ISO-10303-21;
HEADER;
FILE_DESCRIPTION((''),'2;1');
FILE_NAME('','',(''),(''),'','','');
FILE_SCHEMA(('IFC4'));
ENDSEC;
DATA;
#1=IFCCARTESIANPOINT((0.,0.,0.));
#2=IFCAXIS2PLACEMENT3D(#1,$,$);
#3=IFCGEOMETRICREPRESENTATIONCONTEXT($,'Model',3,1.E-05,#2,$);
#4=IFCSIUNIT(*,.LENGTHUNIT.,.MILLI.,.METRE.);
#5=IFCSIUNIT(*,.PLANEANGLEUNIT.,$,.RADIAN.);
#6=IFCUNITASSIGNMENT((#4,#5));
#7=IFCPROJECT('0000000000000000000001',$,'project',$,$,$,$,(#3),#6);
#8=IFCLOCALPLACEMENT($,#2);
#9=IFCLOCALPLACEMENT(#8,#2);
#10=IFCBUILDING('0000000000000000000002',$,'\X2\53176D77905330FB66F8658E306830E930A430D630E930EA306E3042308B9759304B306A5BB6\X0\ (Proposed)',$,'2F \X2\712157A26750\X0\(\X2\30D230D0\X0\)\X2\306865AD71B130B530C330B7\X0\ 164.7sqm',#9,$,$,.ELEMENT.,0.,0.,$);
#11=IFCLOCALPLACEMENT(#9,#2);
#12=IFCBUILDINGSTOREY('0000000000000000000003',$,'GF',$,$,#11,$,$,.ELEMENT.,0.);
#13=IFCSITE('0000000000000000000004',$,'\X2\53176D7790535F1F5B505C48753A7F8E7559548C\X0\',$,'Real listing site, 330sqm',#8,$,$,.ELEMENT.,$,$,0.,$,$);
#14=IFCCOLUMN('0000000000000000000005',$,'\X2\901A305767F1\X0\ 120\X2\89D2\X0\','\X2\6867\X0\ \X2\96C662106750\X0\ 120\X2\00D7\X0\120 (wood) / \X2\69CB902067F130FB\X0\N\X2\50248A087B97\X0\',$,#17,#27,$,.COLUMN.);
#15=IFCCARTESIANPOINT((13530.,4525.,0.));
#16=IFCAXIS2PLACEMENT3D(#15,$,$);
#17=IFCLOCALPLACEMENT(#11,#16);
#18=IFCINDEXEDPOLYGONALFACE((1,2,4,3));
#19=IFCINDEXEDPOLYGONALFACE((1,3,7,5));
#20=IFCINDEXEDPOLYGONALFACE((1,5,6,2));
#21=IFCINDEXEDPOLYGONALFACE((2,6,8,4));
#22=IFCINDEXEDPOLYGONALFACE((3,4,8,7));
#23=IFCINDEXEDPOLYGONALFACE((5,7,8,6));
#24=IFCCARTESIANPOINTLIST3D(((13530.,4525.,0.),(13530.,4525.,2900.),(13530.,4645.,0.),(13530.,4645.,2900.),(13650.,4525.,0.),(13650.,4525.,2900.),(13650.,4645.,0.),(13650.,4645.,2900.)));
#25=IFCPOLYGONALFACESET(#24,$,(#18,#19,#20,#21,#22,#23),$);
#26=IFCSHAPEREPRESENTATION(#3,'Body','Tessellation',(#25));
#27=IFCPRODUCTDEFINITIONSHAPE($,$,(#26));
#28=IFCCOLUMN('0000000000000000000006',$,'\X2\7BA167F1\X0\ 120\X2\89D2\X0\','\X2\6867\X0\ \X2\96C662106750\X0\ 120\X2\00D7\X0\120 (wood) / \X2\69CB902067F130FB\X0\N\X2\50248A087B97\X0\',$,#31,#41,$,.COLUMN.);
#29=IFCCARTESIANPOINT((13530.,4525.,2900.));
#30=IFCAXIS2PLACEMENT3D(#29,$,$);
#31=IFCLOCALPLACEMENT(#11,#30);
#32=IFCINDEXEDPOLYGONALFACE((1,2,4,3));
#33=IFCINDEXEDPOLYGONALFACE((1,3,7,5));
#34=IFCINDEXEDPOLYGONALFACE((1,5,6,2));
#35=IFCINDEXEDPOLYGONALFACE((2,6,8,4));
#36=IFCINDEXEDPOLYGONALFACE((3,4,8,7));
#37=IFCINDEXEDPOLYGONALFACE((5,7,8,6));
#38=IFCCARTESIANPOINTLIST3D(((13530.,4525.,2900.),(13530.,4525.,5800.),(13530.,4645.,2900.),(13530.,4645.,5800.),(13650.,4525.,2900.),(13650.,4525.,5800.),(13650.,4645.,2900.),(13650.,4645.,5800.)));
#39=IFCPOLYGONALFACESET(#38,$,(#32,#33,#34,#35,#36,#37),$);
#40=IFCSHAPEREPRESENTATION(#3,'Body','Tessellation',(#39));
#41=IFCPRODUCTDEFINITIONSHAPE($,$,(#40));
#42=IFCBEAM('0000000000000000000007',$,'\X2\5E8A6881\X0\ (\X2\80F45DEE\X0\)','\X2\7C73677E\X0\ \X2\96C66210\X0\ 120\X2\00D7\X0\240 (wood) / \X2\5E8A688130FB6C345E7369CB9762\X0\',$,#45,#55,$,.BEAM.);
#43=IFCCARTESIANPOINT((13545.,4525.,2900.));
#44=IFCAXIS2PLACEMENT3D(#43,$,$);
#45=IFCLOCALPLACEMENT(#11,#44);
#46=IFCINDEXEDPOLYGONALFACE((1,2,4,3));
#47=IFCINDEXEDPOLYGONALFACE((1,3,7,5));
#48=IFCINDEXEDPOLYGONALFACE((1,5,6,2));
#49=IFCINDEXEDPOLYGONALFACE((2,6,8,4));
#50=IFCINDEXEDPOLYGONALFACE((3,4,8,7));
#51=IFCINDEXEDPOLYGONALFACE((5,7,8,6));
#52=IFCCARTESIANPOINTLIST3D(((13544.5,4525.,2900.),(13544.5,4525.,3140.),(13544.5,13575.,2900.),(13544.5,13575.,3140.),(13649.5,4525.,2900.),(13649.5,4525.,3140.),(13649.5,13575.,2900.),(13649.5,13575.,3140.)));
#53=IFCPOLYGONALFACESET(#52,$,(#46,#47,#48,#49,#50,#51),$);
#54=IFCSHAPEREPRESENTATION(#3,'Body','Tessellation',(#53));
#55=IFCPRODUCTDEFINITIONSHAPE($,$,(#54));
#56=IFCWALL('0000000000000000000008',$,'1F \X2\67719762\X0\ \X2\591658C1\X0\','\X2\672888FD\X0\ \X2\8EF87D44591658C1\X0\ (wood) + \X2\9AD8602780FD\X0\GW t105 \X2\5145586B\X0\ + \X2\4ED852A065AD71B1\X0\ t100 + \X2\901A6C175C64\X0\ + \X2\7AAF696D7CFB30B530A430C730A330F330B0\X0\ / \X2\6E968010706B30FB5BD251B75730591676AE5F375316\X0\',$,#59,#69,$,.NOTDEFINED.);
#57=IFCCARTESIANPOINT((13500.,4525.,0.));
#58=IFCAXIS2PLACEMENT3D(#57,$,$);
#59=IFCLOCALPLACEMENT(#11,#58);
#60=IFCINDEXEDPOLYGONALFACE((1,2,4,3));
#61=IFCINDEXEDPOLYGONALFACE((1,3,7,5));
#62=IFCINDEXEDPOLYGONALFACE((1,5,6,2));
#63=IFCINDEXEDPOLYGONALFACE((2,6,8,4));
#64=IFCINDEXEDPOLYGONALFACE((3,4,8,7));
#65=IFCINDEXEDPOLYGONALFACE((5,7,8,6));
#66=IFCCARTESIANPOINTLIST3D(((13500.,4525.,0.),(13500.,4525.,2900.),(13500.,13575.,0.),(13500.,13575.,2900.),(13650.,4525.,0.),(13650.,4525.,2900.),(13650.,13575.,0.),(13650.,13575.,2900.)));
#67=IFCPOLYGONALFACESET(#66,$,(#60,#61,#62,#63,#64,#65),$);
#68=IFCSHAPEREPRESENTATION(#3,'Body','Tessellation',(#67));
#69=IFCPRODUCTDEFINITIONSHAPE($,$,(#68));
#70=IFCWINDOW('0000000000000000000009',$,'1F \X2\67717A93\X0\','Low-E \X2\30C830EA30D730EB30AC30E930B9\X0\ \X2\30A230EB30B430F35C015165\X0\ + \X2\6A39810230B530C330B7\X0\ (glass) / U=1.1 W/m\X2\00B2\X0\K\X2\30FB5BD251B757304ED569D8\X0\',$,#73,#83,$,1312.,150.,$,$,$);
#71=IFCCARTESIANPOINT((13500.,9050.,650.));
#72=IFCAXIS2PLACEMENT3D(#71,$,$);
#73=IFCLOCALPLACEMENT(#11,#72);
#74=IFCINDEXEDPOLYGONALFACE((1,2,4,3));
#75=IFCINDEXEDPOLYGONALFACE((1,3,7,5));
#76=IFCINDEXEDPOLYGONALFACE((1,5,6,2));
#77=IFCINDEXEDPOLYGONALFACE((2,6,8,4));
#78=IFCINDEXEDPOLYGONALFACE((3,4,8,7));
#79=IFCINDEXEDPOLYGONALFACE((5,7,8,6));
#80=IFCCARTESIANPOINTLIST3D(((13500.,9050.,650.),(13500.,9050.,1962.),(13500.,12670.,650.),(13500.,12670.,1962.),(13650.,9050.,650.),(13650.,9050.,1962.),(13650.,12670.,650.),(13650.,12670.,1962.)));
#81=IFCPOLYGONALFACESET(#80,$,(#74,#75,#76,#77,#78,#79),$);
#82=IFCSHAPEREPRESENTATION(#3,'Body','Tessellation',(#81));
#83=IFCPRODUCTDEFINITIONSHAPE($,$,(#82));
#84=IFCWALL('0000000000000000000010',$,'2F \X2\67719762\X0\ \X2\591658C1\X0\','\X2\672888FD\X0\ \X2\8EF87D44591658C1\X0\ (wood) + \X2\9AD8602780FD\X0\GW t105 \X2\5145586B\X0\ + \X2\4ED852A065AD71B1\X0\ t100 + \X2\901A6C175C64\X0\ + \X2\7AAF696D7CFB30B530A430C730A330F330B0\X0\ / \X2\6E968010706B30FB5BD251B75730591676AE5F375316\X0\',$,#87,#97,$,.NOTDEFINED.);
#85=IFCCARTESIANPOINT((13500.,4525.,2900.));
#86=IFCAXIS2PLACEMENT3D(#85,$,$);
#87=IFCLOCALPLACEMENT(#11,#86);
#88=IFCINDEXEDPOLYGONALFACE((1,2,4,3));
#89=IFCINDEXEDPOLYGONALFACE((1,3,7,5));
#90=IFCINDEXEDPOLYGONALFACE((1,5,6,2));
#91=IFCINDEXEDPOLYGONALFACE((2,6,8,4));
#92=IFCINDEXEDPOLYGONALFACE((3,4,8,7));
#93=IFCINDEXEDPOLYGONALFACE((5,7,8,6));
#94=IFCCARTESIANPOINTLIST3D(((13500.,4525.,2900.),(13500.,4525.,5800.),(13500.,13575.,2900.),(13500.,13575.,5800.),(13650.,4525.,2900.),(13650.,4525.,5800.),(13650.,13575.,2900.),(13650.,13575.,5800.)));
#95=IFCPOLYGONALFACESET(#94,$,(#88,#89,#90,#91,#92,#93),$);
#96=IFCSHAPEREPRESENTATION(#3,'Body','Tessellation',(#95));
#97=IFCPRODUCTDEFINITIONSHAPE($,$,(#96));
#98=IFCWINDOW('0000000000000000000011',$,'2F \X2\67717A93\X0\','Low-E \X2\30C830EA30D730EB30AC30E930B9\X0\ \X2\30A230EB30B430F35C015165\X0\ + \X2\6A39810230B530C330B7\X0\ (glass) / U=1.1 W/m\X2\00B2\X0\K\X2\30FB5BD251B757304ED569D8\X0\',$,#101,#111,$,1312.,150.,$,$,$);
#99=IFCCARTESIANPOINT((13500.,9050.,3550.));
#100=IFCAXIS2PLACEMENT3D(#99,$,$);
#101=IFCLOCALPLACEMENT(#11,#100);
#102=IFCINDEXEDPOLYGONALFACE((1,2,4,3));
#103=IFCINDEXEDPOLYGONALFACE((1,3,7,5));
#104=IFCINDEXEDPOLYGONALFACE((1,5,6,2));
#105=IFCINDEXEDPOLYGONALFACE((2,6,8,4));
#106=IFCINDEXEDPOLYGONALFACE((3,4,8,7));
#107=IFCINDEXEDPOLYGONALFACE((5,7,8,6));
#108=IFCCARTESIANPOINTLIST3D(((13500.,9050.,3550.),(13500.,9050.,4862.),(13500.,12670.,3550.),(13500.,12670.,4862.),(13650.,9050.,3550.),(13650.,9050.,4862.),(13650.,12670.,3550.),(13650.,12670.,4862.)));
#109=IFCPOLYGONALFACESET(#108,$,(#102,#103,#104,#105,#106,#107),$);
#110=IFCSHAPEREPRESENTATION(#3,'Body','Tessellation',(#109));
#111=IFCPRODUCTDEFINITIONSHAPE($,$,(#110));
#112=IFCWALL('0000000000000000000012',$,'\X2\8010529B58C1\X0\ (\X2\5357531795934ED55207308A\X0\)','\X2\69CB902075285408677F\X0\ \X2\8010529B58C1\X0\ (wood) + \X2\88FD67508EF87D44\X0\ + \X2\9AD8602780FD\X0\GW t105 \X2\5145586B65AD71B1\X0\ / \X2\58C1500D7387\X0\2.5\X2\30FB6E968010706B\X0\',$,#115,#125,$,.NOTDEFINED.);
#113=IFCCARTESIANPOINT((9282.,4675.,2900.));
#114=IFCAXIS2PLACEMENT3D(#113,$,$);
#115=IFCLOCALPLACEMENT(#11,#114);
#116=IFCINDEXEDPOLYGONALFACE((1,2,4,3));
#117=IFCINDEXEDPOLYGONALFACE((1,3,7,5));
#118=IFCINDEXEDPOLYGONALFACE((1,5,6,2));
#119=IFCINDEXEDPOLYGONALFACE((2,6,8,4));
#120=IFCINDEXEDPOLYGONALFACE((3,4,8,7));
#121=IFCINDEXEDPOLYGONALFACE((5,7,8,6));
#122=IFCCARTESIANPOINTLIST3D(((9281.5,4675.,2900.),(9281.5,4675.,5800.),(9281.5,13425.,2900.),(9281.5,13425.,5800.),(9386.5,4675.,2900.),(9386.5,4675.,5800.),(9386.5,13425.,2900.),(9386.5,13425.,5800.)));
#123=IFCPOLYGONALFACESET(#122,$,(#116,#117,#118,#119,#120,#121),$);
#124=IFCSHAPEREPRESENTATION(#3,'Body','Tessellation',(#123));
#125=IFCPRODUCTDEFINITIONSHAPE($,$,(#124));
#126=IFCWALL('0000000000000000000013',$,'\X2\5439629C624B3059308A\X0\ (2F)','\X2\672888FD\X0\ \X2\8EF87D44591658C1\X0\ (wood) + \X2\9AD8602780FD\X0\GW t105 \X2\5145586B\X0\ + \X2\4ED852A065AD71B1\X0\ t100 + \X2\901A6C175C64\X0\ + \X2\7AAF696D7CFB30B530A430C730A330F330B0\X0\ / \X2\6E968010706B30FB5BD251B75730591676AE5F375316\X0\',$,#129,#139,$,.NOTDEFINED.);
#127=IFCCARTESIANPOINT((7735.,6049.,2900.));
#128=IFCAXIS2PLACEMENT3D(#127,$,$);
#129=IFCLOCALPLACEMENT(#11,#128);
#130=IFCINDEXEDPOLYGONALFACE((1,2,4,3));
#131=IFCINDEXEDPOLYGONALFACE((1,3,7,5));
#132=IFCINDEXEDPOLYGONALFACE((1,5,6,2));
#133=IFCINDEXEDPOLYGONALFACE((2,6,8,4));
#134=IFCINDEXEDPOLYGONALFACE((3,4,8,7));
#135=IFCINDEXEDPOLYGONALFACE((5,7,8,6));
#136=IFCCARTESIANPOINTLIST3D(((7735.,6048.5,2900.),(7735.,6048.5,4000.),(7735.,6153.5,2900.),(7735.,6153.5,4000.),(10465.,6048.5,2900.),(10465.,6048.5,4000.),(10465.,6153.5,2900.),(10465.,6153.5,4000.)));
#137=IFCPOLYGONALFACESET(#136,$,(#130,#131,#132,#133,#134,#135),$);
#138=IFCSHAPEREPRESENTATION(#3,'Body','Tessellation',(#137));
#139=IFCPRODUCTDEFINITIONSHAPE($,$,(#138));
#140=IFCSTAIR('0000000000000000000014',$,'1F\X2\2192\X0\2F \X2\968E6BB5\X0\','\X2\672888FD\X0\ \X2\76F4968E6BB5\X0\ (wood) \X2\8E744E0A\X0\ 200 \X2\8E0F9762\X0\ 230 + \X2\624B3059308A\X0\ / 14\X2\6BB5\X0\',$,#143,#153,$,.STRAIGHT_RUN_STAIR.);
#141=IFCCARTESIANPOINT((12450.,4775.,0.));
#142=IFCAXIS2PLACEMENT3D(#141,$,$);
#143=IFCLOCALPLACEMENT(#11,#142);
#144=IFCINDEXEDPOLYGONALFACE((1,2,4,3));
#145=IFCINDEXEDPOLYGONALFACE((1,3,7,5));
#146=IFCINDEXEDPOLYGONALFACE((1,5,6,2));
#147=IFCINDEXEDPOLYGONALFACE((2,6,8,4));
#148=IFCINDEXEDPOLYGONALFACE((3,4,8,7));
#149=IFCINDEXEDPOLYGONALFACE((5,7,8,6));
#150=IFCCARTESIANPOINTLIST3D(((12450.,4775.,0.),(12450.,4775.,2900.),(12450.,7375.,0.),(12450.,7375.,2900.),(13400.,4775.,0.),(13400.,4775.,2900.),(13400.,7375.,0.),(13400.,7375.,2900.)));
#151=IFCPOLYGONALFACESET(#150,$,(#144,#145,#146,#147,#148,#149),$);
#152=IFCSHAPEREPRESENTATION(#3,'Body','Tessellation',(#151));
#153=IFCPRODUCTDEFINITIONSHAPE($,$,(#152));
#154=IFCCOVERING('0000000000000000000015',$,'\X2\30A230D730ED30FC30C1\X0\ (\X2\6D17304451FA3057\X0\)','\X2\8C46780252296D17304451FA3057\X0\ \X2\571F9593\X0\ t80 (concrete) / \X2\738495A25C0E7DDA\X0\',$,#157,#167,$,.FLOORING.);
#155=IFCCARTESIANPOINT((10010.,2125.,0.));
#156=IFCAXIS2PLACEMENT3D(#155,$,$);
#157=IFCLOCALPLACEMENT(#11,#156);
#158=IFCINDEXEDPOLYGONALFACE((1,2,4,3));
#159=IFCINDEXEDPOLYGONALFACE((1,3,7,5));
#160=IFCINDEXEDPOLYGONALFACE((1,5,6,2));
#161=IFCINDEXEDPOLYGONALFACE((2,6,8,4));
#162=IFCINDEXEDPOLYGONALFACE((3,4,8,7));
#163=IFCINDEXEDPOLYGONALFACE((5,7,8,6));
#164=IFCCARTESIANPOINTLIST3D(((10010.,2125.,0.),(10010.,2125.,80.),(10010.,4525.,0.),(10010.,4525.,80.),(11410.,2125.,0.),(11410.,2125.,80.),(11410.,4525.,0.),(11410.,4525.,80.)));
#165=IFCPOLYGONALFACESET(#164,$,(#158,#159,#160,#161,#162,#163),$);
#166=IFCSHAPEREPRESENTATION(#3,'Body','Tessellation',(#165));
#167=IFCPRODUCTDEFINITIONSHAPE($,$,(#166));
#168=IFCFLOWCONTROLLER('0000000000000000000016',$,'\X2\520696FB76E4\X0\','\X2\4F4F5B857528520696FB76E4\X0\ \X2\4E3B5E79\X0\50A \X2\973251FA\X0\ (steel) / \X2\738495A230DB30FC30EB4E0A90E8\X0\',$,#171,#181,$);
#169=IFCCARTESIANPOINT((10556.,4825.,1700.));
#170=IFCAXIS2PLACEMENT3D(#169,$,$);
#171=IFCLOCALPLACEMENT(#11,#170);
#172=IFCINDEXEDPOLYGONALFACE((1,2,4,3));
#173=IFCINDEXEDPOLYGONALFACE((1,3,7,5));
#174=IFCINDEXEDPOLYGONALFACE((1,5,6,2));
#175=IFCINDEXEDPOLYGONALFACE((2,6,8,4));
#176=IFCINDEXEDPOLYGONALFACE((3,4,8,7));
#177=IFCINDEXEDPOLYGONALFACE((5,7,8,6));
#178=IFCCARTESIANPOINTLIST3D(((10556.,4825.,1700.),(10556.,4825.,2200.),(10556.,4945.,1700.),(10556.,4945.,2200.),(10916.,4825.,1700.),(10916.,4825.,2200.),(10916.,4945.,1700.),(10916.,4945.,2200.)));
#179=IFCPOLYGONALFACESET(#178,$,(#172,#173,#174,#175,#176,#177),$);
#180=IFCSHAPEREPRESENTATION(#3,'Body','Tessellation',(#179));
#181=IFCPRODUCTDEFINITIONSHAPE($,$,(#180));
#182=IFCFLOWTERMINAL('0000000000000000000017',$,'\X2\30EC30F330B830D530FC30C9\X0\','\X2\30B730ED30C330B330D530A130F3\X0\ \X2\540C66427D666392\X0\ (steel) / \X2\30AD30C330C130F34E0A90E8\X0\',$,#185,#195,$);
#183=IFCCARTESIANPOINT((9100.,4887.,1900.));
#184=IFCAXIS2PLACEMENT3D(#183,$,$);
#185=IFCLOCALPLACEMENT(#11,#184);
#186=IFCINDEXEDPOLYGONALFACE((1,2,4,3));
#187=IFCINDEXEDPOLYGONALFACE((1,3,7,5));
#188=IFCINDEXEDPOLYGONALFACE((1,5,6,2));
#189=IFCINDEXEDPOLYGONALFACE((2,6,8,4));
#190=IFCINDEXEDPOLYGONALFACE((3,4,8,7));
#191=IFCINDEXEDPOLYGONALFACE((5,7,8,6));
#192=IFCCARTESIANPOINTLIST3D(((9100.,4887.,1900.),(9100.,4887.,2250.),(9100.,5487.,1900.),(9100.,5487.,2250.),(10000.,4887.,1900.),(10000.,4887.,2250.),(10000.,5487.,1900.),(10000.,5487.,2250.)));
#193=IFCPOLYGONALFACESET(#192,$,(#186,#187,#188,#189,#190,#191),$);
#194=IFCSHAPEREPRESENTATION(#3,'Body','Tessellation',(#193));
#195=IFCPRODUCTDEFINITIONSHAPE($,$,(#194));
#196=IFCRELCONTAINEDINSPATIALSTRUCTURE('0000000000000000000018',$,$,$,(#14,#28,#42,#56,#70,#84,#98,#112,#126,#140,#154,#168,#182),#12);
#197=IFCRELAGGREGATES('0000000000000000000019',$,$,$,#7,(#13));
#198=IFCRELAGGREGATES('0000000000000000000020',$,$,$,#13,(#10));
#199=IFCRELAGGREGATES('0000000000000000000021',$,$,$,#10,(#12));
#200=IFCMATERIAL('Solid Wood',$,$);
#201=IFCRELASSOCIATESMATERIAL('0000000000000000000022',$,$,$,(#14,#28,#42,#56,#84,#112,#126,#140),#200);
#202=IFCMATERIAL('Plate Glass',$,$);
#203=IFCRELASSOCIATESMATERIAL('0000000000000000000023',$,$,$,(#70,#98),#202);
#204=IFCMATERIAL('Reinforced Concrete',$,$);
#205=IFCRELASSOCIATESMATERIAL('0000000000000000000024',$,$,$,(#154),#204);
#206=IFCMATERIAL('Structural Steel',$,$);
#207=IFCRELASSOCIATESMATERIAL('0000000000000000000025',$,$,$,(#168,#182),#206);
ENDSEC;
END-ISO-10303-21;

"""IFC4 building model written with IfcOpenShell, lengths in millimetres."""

from ifc_helpers import new_model, si_unit, frame, frame_2d, origin, place, context, project, spatial, rectangle, extrude, material, element, fill, save


model = new_model("IFC4")

# Units and contexts
model_context = context("Model", 3, precision=1e-05, world=origin())
ifc_project = project(units=[si_unit("LENGTHUNIT", "METRE", prefix="MILLI"), si_unit("PLANEANGLEUNIT", "RADIAN")], contexts=[model_context])

# Site, building, storey
site_placement = place(None, origin())
site = spatial("IfcSite", under=ifc_project, at=site_placement, Name="北海道弟子屈町美留和", ObjectType="Real listing site, 330sqm", CompositionType="ELEMENT", RefElevation=0.0)
building_placement = place(site_placement, origin())
building = spatial("IfcBuilding", under=site, at=building_placement, Name="北海道・書斎とライブラリのある静かな家 (Proposed)", ObjectType="2F 無垢材(ヒバ)と断熱サッシ 164.7sqm", CompositionType="ELEMENT", ElevationOfRefHeight=0.0, ElevationOfTerrain=0.0)
storey_placement = place(building_placement, origin())
storey = spatial("IfcBuildingStorey", under=building, at=storey_placement, Name="GF", CompositionType="ELEMENT", Elevation=0.0)

# Columns
ifc_material_1 = material(Name="Solid Wood")
column_1_placement = place(storey_placement, frame((13530.0, 4525.0, 0.0)))
element("IfcColumn", 1, at=column_1_placement, inside=storey, material=ifc_material_1, Name="通し柱 120角", Description="桧 集成材 120×120 (wood) / 構造柱・N値計算", PredefinedType="COLUMN", context=model_context, shape_type="SweptSolid", body=[
    extrude(rectangle(XDim=120.0, YDim=120.0, at=frame_2d((60.0, 60.0))), frame((13530.0, 4525.0, 0.0)), (0.0, 0.0, 1.0), 2900.0),
])
column_2_placement = place(storey_placement, frame((13530.0, 4525.0, 2900.0)))
element("IfcColumn", 2, at=column_2_placement, inside=storey, material=ifc_material_1, Name="管柱 120角", Description="桧 集成材 120×120 (wood) / 構造柱・N値計算", PredefinedType="COLUMN", context=model_context, shape_type="SweptSolid", body=[
    extrude(rectangle(XDim=120.0, YDim=120.0, at=frame_2d((60.0, 60.0))), frame((13530.0, 4525.0, 2900.0)), (0.0, 0.0, 1.0), 2900.0),
])

# Beam
beam_1_placement = place(storey_placement, frame((13545.0, 4525.0, 2900.0)))
element("IfcBeam", 3, at=beam_1_placement, inside=storey, material=ifc_material_1, Name="床梁 (胴差)", Description="米松 集成 120×240 (wood) / 床梁・水平構面", PredefinedType="BEAM", context=model_context, shape_type="SweptSolid", body=[
    extrude(rectangle(XDim=105.0, YDim=9050.0, at=frame_2d((52.0, 4525.0))), frame((13545.0, 4525.0, 2900.0)), (0.0, 0.0, 1.0), 240.0),
])

# Wall, opening, window
wall_1_placement = place(storey_placement, frame((13500.0, 4525.0, 0.0)))
wall_1 = element("IfcWall", 4, at=wall_1_placement, inside=storey, material=ifc_material_1, Name="1F 東面 外壁", Description="木製 軸組外壁 (wood) + 高性能GW t105 充填 + 付加断熱 t100 + 通気層 + 窯業系サイディング / 準耐火・寒冷地外皮強化", PredefinedType="NOTDEFINED", context=model_context, shape_type="SweptSolid", body=[
    extrude(rectangle(XDim=150.0, YDim=9050.0, at=frame_2d((75.0, 4525.0))), frame((13500.0, 4525.0, 0.0)), (0.0, 0.0, 1.0), 2900.0),
])
opening_1_placement = place(storey_placement, frame((13500.0, 9050.0, 650.0)))
opening_1 = element("IfcOpeningElement", 5, at=opening_1_placement, cuts=wall_1, PredefinedType="NOTDEFINED", context=model_context, shape_type="SweptSolid", body=[
    extrude(rectangle(XDim=150.0, YDim=3620.0, at=frame_2d((75.0, 1810.0))), frame((13500.0, 9050.0, 650.0)), (0.0, 0.0, 1.0), 1312.0),
])
ifc_material_2 = material(Name="Plate Glass")
window_1_placement = place(storey_placement, frame((13500.0, 9050.0, 650.0)))
window_1 = element("IfcWindow", 6, at=window_1_placement, inside=storey, material=ifc_material_2, Name="1F 東窓", Description="Low-E トリプルガラス アルゴン封入 + 樹脂サッシ (glass) / U=1.1 W/m²K・寒冷地仕様", OverallHeight=1312.0, OverallWidth=150.0, context=model_context, shape_type="SweptSolid", body=[
    extrude(rectangle(XDim=150.0, YDim=3620.0, at=frame_2d((75.0, 1810.0))), frame((13500.0, 9050.0, 650.0)), (0.0, 0.0, 1.0), 1312.0),
])
fill(opening_1, window_1)

# Wall, opening, window
wall_2_placement = place(storey_placement, frame((13500.0, 4525.0, 2900.0)))
wall_2 = element("IfcWall", 7, at=wall_2_placement, inside=storey, material=ifc_material_1, Name="2F 東面 外壁", Description="木製 軸組外壁 (wood) + 高性能GW t105 充填 + 付加断熱 t100 + 通気層 + 窯業系サイディング / 準耐火・寒冷地外皮強化", PredefinedType="NOTDEFINED", context=model_context, shape_type="SweptSolid", body=[
    extrude(rectangle(XDim=150.0, YDim=9050.0, at=frame_2d((75.0, 4525.0))), frame((13500.0, 4525.0, 2900.0)), (0.0, 0.0, 1.0), 2900.0),
])
opening_2_placement = place(storey_placement, frame((13500.0, 9050.0, 3550.0)))
opening_2 = element("IfcOpeningElement", 8, at=opening_2_placement, cuts=wall_2, PredefinedType="NOTDEFINED", context=model_context, shape_type="SweptSolid", body=[
    extrude(rectangle(XDim=150.0, YDim=3620.0, at=frame_2d((75.0, 1810.0))), frame((13500.0, 9050.0, 3550.0)), (0.0, 0.0, 1.0), 1312.0),
])
window_2_placement = place(storey_placement, frame((13500.0, 9050.0, 3550.0)))
window_2 = element("IfcWindow", 9, at=window_2_placement, inside=storey, material=ifc_material_2, Name="2F 東窓", Description="Low-E トリプルガラス アルゴン封入 + 樹脂サッシ (glass) / U=1.1 W/m²K・寒冷地仕様", OverallHeight=1312.0, OverallWidth=150.0, context=model_context, shape_type="SweptSolid", body=[
    extrude(rectangle(XDim=150.0, YDim=3620.0, at=frame_2d((75.0, 1810.0))), frame((13500.0, 9050.0, 3550.0)), (0.0, 0.0, 1.0), 1312.0),
])
fill(opening_2, window_2)

# Walls
wall_3_placement = place(storey_placement, frame((9282.0, 4675.0, 2900.0)))
element("IfcWall", 10, at=wall_3_placement, inside=storey, material=ifc_material_1, Name="耐力壁 (南北間仕切り)", Description="構造用合板 耐力壁 (wood) + 製材軸組 + 高性能GW t105 充填断熱 / 壁倍率2.5・準耐火", PredefinedType="NOTDEFINED", context=model_context, shape_type="SweptSolid", body=[
    extrude(rectangle(XDim=105.0, YDim=8750.0, at=frame_2d((52.0, 4375.0))), frame((9282.0, 4675.0, 2900.0)), (0.0, 0.0, 1.0), 2900.0),
])
wall_4_placement = place(storey_placement, frame((7735.0, 6049.0, 2900.0)))
element("IfcWall", 11, at=wall_4_placement, inside=storey, material=ifc_material_1, Name="吹抜手すり (2F)", Description="木製 軸組外壁 (wood) + 高性能GW t105 充填 + 付加断熱 t100 + 通気層 + 窯業系サイディング / 準耐火・寒冷地外皮強化", PredefinedType="NOTDEFINED", context=model_context, shape_type="SweptSolid", body=[
    extrude(rectangle(XDim=2730.0, YDim=105.0, at=frame_2d((1365.0, 52.0))), frame((7735.0, 6049.0, 2900.0)), (0.0, 0.0, 1.0), 1100.0),
])

# Stair
stair_placement = place(storey_placement, frame((12450.0, 4775.0, 0.0)))
element("IfcStair", 12, at=stair_placement, inside=storey, material=ifc_material_1, Name="1F→2F 階段", Description="木製 直階段 (wood) 蹴上 200 踏面 230 + 手すり / 14段", PredefinedType="STRAIGHT_RUN_STAIR", context=model_context, shape_type="SweptSolid", body=[
    extrude(rectangle(XDim=950.0, YDim=2600.0, at=frame_2d((475.0, 1300.0))), frame((12450.0, 4775.0, 0.0)), (0.0, 0.0, 1.0), 2900.0),
])

# Covering
ifc_material_3 = material(Name="Reinforced Concrete")
covering_placement = place(storey_placement, frame((10010.0, 2125.0, 0.0)))
element("IfcCovering", 13, at=covering_placement, inside=storey, material=ifc_material_3, Name="アプローチ (洗い出し)", Description="豆砂利洗い出し 土間 t80 (concrete) / 玄関導線", PredefinedType="FLOORING", context=model_context, shape_type="SweptSolid", body=[
    extrude(rectangle(XDim=1400.0, YDim=2400.0, at=frame_2d((700.0, 1200.0))), frame((10010.0, 2125.0, 0.0)), (0.0, 0.0, 1.0), 80.0),
])

# Flow controller
ifc_material_4 = material(Name="Structural Steel")
flow_controller_placement = place(storey_placement, frame((10556.0, 4825.0, 1700.0)))
element("IfcFlowController", 14, at=flow_controller_placement, inside=storey, material=ifc_material_4, Name="分電盤", Description="住宅用分電盤 主幹50A 露出 (steel) / 玄関ホール上部", context=model_context, shape_type="SweptSolid", body=[
    extrude(rectangle(XDim=360.0, YDim=120.0, at=frame_2d((180.0, 60.0))), frame((10556.0, 4825.0, 1700.0)), (0.0, 0.0, 1.0), 500.0),
])

# Flow terminal
flow_terminal_1_placement = place(storey_placement, frame((9100.0, 4887.0, 1900.0)))
element("IfcFlowTerminal", 15, at=flow_terminal_1_placement, inside=storey, material=ifc_material_4, Name="レンジフード", Description="シロッコファン 同時給排 (steel) / キッチン上部", context=model_context, shape_type="SweptSolid", body=[
    extrude(rectangle(XDim=900.0, YDim=600.0, at=frame_2d((450.0, 300.0))), frame((9100.0, 4887.0, 1900.0)), (0.0, 0.0, 1.0), 350.0),
])

save(model, "model.ifc")
